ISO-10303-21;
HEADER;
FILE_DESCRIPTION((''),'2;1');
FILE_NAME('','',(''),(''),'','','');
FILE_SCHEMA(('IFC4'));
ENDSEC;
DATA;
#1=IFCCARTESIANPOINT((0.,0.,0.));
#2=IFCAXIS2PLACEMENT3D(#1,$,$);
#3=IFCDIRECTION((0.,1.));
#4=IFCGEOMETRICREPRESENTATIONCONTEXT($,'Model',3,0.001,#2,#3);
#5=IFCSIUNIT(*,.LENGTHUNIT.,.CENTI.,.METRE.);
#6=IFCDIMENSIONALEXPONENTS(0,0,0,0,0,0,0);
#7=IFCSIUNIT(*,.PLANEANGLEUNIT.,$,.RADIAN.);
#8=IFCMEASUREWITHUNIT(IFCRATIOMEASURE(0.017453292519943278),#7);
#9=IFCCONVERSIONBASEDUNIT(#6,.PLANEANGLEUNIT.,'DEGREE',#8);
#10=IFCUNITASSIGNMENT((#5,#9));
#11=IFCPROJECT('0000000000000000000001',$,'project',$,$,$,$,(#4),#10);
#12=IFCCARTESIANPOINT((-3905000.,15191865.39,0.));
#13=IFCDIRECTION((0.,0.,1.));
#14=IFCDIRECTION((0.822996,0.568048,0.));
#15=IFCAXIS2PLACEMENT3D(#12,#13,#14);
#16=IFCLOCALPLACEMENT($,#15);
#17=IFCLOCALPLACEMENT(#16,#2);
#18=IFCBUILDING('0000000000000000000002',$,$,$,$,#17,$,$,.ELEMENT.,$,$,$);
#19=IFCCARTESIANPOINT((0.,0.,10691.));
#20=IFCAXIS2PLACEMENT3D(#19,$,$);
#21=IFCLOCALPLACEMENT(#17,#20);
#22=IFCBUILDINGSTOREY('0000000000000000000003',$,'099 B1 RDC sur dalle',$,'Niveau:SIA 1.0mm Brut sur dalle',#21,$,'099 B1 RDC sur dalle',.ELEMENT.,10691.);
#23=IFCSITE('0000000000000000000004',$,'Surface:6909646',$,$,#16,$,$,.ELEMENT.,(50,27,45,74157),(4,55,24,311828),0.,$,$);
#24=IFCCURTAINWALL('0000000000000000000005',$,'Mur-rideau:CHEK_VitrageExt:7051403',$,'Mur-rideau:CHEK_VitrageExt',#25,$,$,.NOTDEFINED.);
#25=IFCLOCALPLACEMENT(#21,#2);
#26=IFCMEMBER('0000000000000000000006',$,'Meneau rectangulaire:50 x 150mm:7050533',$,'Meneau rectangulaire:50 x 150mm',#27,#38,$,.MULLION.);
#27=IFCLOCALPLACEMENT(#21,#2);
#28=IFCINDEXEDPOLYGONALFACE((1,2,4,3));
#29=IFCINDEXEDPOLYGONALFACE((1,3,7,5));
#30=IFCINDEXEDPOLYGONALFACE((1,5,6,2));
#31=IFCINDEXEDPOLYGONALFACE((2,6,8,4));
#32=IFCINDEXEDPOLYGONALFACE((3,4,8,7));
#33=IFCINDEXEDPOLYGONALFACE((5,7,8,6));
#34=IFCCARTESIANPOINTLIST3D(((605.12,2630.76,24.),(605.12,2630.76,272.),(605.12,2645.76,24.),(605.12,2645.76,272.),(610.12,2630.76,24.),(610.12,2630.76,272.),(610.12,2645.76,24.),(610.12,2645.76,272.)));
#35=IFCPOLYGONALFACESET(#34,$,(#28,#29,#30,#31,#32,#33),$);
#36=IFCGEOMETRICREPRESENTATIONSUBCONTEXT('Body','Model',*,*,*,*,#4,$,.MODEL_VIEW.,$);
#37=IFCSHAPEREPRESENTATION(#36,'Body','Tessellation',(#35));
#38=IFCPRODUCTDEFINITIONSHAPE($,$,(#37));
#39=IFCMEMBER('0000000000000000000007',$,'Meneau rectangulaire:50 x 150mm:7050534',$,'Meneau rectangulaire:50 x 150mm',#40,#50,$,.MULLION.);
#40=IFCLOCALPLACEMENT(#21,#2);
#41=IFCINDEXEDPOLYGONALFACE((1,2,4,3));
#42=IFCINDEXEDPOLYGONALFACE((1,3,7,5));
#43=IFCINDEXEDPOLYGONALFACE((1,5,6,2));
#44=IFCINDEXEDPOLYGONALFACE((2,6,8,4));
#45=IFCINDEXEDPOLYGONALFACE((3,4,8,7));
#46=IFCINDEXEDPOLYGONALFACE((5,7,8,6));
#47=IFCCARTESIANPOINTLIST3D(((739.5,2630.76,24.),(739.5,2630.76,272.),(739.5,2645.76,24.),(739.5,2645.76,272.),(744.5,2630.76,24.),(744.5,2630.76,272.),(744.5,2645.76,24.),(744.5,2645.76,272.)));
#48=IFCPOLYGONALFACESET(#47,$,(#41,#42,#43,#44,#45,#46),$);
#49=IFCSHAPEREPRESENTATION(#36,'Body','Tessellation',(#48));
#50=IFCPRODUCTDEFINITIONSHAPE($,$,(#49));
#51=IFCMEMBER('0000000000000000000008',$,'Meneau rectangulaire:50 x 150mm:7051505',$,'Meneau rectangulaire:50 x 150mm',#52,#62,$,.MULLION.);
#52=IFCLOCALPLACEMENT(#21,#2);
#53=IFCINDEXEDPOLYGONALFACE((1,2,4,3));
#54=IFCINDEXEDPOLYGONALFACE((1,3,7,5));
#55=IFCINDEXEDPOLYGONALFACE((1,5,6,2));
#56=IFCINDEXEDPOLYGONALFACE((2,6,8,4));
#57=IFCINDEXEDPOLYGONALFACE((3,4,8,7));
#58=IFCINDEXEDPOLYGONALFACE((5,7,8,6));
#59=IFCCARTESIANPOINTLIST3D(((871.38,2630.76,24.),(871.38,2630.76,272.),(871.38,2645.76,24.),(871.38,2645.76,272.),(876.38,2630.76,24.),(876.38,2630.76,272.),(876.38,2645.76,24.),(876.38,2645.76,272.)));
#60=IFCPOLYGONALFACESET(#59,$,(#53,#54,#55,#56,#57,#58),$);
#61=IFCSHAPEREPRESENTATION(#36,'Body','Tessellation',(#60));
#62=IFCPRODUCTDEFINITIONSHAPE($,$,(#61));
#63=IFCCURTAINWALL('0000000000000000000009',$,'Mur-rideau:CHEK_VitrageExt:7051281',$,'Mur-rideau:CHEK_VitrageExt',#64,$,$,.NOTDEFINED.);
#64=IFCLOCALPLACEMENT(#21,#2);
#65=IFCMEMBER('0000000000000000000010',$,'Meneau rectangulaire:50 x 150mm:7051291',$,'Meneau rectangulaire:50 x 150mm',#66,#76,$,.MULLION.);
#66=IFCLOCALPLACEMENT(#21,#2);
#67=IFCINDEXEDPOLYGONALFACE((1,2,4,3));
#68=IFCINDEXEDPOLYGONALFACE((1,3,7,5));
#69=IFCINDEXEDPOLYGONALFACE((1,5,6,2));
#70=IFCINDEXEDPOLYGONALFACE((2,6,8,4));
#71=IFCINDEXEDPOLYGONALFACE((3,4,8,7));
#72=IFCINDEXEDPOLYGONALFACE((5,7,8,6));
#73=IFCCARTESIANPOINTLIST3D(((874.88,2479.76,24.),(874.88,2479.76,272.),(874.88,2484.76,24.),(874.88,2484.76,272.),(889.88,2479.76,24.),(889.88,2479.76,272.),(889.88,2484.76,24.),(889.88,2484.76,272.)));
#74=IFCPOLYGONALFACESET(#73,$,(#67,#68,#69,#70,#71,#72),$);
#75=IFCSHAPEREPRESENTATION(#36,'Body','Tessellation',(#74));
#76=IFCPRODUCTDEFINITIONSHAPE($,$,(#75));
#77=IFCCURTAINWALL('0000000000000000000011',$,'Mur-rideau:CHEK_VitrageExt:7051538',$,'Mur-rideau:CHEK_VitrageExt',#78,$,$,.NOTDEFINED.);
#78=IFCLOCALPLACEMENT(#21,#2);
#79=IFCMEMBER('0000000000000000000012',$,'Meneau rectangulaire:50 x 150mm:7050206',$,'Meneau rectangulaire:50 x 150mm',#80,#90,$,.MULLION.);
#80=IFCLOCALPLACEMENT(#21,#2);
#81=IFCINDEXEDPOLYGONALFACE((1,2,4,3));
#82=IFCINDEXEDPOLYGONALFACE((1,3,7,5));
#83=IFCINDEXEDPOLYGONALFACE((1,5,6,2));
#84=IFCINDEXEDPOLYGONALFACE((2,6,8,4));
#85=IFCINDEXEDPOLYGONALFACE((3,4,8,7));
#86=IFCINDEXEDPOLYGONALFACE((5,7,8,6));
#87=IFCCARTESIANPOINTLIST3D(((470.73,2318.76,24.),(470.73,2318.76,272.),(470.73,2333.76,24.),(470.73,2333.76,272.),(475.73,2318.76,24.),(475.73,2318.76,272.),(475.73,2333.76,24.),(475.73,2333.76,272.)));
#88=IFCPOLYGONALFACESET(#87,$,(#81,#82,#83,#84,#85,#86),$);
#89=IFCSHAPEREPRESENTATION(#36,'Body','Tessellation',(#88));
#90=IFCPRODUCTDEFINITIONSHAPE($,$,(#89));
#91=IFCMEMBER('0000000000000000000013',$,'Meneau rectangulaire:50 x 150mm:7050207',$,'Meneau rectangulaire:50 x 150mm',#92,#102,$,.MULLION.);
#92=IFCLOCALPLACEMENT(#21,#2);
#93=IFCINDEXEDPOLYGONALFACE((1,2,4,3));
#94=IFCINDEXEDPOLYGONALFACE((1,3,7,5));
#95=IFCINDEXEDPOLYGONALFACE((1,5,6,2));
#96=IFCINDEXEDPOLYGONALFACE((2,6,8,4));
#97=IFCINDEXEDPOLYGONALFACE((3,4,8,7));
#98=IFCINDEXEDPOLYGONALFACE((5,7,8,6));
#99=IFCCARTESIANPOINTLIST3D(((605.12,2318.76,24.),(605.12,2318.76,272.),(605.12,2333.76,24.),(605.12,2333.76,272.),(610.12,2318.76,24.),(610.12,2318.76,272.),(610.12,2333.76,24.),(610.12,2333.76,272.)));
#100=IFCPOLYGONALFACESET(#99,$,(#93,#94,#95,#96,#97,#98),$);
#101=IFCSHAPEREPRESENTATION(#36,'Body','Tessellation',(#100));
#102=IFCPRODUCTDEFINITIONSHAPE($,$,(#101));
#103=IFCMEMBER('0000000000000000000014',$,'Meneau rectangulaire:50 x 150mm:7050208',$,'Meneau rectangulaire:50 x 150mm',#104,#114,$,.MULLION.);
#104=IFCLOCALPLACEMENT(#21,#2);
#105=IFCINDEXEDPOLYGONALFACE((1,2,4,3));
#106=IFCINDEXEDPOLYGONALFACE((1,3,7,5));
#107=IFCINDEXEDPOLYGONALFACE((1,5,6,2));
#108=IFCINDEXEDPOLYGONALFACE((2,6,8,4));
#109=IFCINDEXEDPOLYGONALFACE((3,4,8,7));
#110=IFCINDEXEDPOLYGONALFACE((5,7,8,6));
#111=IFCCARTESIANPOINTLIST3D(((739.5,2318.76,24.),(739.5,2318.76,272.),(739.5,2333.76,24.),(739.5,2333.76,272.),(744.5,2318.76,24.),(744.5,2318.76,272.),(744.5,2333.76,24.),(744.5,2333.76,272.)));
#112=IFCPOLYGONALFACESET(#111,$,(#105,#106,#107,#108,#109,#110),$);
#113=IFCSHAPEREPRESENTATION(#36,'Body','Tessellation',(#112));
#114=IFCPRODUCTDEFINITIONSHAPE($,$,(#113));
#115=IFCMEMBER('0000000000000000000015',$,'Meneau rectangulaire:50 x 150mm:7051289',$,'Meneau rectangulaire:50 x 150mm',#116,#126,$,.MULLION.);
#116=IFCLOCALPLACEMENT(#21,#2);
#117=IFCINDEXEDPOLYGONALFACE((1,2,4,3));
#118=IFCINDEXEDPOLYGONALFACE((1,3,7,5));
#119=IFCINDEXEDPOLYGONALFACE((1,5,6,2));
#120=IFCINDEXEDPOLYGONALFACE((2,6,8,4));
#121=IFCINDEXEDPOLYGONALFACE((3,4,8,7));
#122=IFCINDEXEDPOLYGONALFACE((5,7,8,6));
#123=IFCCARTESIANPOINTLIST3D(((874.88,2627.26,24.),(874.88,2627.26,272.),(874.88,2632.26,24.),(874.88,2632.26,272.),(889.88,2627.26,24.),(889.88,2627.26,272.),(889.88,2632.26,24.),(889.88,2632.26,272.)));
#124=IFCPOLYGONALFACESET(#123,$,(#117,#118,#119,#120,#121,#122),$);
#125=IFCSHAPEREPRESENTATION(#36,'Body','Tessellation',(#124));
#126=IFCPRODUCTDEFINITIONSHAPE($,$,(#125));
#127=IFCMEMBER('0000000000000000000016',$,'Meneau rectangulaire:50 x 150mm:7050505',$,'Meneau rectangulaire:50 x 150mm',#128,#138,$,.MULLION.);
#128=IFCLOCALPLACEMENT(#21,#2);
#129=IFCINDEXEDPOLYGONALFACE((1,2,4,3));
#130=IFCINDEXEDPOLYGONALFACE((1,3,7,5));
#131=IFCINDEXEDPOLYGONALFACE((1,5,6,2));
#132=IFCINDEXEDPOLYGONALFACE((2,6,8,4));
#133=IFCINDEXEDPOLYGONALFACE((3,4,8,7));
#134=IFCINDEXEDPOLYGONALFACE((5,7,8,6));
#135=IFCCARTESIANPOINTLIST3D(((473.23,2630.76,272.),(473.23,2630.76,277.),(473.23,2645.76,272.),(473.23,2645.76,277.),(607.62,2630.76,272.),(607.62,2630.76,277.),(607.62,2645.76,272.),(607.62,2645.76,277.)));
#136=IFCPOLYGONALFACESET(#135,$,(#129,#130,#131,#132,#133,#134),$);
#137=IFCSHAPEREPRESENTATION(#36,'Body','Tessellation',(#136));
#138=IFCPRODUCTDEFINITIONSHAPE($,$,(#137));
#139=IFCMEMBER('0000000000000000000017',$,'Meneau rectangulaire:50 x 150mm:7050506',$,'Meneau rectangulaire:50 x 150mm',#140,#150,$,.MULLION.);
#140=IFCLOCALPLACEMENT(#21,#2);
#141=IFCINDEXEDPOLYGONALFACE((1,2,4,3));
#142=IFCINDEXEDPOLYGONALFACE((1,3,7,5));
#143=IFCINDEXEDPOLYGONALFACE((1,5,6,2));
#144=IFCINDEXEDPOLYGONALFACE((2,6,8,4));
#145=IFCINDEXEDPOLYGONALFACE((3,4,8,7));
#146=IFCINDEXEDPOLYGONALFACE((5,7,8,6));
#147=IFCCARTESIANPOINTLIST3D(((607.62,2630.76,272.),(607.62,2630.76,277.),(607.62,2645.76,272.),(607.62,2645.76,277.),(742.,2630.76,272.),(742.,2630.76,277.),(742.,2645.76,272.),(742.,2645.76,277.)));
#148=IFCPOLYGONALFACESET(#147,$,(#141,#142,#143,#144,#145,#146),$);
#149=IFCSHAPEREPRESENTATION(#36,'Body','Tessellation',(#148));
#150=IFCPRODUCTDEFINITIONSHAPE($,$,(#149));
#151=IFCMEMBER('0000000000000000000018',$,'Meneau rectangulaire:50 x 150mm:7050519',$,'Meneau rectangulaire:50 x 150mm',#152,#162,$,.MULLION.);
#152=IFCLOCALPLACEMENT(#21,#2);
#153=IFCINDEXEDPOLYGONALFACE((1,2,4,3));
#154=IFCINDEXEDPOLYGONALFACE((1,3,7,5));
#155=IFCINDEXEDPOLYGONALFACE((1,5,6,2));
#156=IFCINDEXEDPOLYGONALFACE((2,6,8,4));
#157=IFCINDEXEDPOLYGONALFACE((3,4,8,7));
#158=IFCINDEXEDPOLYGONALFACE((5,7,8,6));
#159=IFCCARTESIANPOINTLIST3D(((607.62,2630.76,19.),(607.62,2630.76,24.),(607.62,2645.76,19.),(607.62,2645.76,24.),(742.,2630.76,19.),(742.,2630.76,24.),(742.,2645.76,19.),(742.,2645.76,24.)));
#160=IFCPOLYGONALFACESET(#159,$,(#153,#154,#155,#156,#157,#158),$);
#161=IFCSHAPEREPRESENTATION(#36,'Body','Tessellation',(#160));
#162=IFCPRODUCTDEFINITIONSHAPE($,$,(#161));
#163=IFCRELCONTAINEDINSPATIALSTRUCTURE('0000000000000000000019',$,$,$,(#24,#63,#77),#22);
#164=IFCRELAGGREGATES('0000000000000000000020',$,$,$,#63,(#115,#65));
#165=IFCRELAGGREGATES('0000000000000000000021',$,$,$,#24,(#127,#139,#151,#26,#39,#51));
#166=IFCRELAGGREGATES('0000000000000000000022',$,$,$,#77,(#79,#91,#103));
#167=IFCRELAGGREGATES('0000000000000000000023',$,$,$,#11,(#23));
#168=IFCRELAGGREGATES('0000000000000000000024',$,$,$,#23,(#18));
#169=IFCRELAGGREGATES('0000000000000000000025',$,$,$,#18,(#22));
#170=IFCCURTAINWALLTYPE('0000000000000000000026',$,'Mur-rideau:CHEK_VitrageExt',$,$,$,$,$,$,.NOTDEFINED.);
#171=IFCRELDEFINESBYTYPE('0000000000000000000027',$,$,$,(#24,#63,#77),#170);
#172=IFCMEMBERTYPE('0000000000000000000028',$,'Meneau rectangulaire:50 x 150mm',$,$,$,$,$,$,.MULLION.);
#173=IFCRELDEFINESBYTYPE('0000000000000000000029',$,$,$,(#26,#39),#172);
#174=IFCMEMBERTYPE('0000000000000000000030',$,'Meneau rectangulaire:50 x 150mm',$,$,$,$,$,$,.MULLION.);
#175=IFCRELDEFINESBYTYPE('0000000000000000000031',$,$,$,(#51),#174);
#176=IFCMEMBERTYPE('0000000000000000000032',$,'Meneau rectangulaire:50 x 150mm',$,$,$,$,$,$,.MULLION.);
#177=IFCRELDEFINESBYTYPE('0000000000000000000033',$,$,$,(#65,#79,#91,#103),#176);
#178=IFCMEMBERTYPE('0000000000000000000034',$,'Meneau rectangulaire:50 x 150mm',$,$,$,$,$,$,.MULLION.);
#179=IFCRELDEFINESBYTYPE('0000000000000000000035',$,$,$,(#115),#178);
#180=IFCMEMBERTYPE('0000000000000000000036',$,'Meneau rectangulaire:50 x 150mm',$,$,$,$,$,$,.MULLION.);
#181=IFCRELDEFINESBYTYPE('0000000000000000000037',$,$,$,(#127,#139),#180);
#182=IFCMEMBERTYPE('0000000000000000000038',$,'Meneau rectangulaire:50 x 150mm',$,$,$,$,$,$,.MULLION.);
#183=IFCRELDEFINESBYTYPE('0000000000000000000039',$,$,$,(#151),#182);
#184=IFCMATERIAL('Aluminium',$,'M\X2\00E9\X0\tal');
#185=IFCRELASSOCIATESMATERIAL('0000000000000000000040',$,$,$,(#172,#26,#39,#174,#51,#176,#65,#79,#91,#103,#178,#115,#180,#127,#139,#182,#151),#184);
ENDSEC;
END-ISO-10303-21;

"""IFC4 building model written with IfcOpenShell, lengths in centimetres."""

from ifc_helpers import new_model, entity, si_unit, converted_unit, direction, frame, origin, place, context, subcontext, project, spatial, indexed_curve, outline, extrude, source, transform, mapped, material, type_object, type_shapes, element, aggregate, save


model = new_model("IFC4")

# Units and contexts
model_context = context("Model", 3, precision=0.001, world=origin(), true_north=direction((0.0, 1.0)))
body_context = subcontext(model_context, "Body", "Model", "MODEL_VIEW")
ifc_project = project(units=[si_unit("LENGTHUNIT", "METRE", prefix="CENTI"), converted_unit("PLANEANGLEUNIT", "DEGREE", entity("IfcRatioMeasure", 0.017453292519943278), si_unit("PLANEANGLEUNIT", "RADIAN"), dimensions=[0, 0, 0, 0, 0, 0, 0])], contexts=[model_context])

# Site, building, storey
site_placement = place(None, frame((-3905000.0, 15191865.39, 0.0), z_axis=(0.0, 0.0, 1.0), x_axis=(0.822996, 0.568048, 0.0)))
site = spatial("IfcSite", under=ifc_project, at=site_placement, Name="Surface:6909646", CompositionType="ELEMENT", RefLatitude=(50, 27, 45, 74157), RefLongitude=(4, 55, 24, 311828), RefElevation=0.0)
building_placement = place(site_placement, origin())
building = spatial("IfcBuilding", under=site, at=building_placement, CompositionType="ELEMENT")
storey_placement = place(building_placement, frame((0.0, 0.0, 10691.0)))
storey = spatial("IfcBuildingStorey", under=building, at=storey_placement, Name="099 B1 RDC sur dalle", ObjectType="Niveau:SIA 1.0mm Brut sur dalle", LongName="099 B1 RDC sur dalle", CompositionType="ELEMENT", Elevation=10691.0)

# Curtain wall, members
curtain_wall_type = type_object("IfcCurtainWallType", Name="Mur-rideau:CHEK_VitrageExt", PredefinedType="NOTDEFINED")
curtain_wall_1_placement = place(storey_placement, frame((0.0, 0.0, -10691.0)))
curtain_wall_1 = element("IfcCurtainWall", 1, at=curtain_wall_1_placement, inside=storey, type_object=curtain_wall_type, Name="Mur-rideau:CHEK_VitrageExt:7051403", ObjectType="Mur-rideau:CHEK_VitrageExt", PredefinedType="NOTDEFINED")
ifc_material_1 = material(Name="Aluminium", Category="Métal")
member_type_1 = type_object("IfcMemberType", Name="Meneau rectangulaire:50 x 150mm", PredefinedType="MULLION", material=ifc_material_1)
shared_shape_1 = source(origin(), body_context, "Body", "SweptSolid", [
    extrude(outline(indexed_curve([(-7.5, -2.5), (7.5, -2.5), (7.5, 2.5), (-7.5, 2.5), (-7.5, -2.5)], self_intersect=False)), frame((0.0, -6.0, -248.0), z_axis=(0.0, 0.0, 1.0), x_axis=(0.0, -1.0, 0.0)), (0.0, 0.0, 1.0), 248.0),
])
type_shapes(member_type_1, [shared_shape_1])
member_1_placement = place(curtain_wall_1_placement, frame((607.62, 2632.26, 10715.0), z_axis=(0.0, 0.0, -1.0), x_axis=(1.0, 0.0, 0.0)))
member_1 = element("IfcMember", 2, at=member_1_placement, type_object=member_type_1, material=ifc_material_1, Name="Meneau rectangulaire:50 x 150mm:7050533", ObjectType="Meneau rectangulaire:50 x 150mm", PredefinedType="MULLION", context=body_context, shape_type="MappedRepresentation", body=[
    mapped(shared_shape_1, transform((0.0, 0.0, 0.0), scale=1.0)),
])
member_2_placement = place(curtain_wall_1_placement, frame((742.0, 2632.26, 10715.0), z_axis=(0.0, 0.0, -1.0), x_axis=(1.0, 0.0, 0.0)))
member_2 = element("IfcMember", 3, at=member_2_placement, type_object=member_type_1, material=ifc_material_1, Name="Meneau rectangulaire:50 x 150mm:7050534", ObjectType="Meneau rectangulaire:50 x 150mm", PredefinedType="MULLION", context=body_context, shape_type="MappedRepresentation", body=[
    mapped(shared_shape_1, transform((0.0, 0.0, 0.0), scale=1.0)),
])
member_type_2 = type_object("IfcMemberType", Name="Meneau rectangulaire:50 x 150mm", PredefinedType="MULLION", material=ifc_material_1)
shared_shape_2 = source(origin(), body_context, "Body", "SweptSolid", [
    extrude(outline(indexed_curve([(-7.5, -2.5), (7.5, -2.5), (7.5, 2.5), (-7.5, 2.5), (-7.5, -2.5)], self_intersect=False)), frame((-2.5, -6.0, -248.0), z_axis=(0.0, 0.0, 1.0), x_axis=(0.0, -1.0, 0.0)), (0.0, 0.0, 1.0), 248.0),
])
type_shapes(member_type_2, [shared_shape_2])
member_3_placement = place(curtain_wall_1_placement, frame((876.38, 2632.26, 10715.0), z_axis=(0.0, 0.0, -1.0), x_axis=(1.0, 0.0, 0.0)))
member_3 = element("IfcMember", 4, at=member_3_placement, type_object=member_type_2, material=ifc_material_1, Name="Meneau rectangulaire:50 x 150mm:7051505", ObjectType="Meneau rectangulaire:50 x 150mm", PredefinedType="MULLION", context=body_context, shape_type="MappedRepresentation", body=[
    mapped(shared_shape_2, transform((0.0, 0.0, 0.0), scale=1.0)),
])

# Curtain wall, member
curtain_wall_2_placement = place(storey_placement, frame((0.0, 0.0, -10691.0)))
curtain_wall_2 = element("IfcCurtainWall", 5, at=curtain_wall_2_placement, inside=storey, type_object=curtain_wall_type, Name="Mur-rideau:CHEK_VitrageExt:7051281", ObjectType="Mur-rideau:CHEK_VitrageExt", PredefinedType="NOTDEFINED")
member_type_3 = type_object("IfcMemberType", Name="Meneau rectangulaire:50 x 150mm", PredefinedType="MULLION", material=ifc_material_1)
shared_shape_3 = source(origin(), body_context, "Body", "SweptSolid", [
    extrude(outline(indexed_curve([(-7.5, -2.5), (7.5, -2.5), (7.5, 2.5), (-7.5, 2.5), (-7.5, -2.5)], self_intersect=False)), frame((0.0, 6.0, -248.0), z_axis=(0.0, 0.0, 1.0), x_axis=(0.0, -1.0, 0.0)), (0.0, 0.0, 1.0), 248.0),
])
type_shapes(member_type_3, [shared_shape_3])
member_4_placement = place(curtain_wall_2_placement, frame((876.38, 2482.26, 10715.0), z_axis=(0.0, 0.0, -1.0), x_axis=(0.0, 1.0, 0.0)))
member_4 = element("IfcMember", 6, at=member_4_placement, type_object=member_type_3, material=ifc_material_1, Name="Meneau rectangulaire:50 x 150mm:7051291", ObjectType="Meneau rectangulaire:50 x 150mm", PredefinedType="MULLION", context=body_context, shape_type="MappedRepresentation", body=[
    mapped(shared_shape_3, transform((0.0, 0.0, 0.0), scale=1.0)),
])

# Curtain wall, members
curtain_wall_3_placement = place(storey_placement, frame((0.0, 0.0, -10691.0)))
curtain_wall_3 = element("IfcCurtainWall", 7, at=curtain_wall_3_placement, inside=storey, type_object=curtain_wall_type, Name="Mur-rideau:CHEK_VitrageExt:7051538", ObjectType="Mur-rideau:CHEK_VitrageExt", PredefinedType="NOTDEFINED")
member_5_placement = place(curtain_wall_3_placement, frame((473.23, 2332.26, 10715.0), z_axis=(0.0, 0.0, -1.0), x_axis=(1.0, 0.0, 0.0)))
member_5 = element("IfcMember", 8, at=member_5_placement, type_object=member_type_3, material=ifc_material_1, Name="Meneau rectangulaire:50 x 150mm:7050206", ObjectType="Meneau rectangulaire:50 x 150mm", PredefinedType="MULLION", context=body_context, shape_type="MappedRepresentation", body=[
    mapped(shared_shape_3, transform((0.0, 0.0, 0.0), scale=1.0)),
])
member_6_placement = place(curtain_wall_3_placement, frame((607.62, 2332.26, 10715.0), z_axis=(0.0, 0.0, -1.0), x_axis=(1.0, 0.0, 0.0)))
member_6 = element("IfcMember", 9, at=member_6_placement, type_object=member_type_3, material=ifc_material_1, Name="Meneau rectangulaire:50 x 150mm:7050207", ObjectType="Meneau rectangulaire:50 x 150mm", PredefinedType="MULLION", context=body_context, shape_type="MappedRepresentation", body=[
    mapped(shared_shape_3, transform((0.0, 0.0, 0.0), scale=1.0)),
])
member_7_placement = place(curtain_wall_3_placement, frame((742.0, 2332.26, 10715.0), z_axis=(0.0, 0.0, -1.0), x_axis=(1.0, 0.0, 0.0)))
member_7 = element("IfcMember", 10, at=member_7_placement, type_object=member_type_3, material=ifc_material_1, Name="Meneau rectangulaire:50 x 150mm:7050208", ObjectType="Meneau rectangulaire:50 x 150mm", PredefinedType="MULLION", context=body_context, shape_type="MappedRepresentation", body=[
    mapped(shared_shape_3, transform((0.0, 0.0, 0.0), scale=1.0)),
])

# Members
member_type_4 = type_object("IfcMemberType", Name="Meneau rectangulaire:50 x 150mm", PredefinedType="MULLION", material=ifc_material_1)
shared_shape_4 = source(origin(), body_context, "Body", "SweptSolid", [
    extrude(outline(indexed_curve([(-7.5, -2.5), (7.5, -2.5), (7.5, 2.5), (-7.5, 2.5), (-7.5, -2.5)], self_intersect=False)), frame((-2.5, 6.0, -248.0), z_axis=(0.0, 0.0, 1.0), x_axis=(0.0, -1.0, 0.0)), (0.0, 0.0, 1.0), 248.0),
])
type_shapes(member_type_4, [shared_shape_4])
member_8_placement = place(curtain_wall_2_placement, frame((876.38, 2632.26, 10715.0), z_axis=(0.0, 0.0, -1.0), x_axis=(0.0, 1.0, 0.0)))
member_8 = element("IfcMember", 11, at=member_8_placement, type_object=member_type_4, material=ifc_material_1, Name="Meneau rectangulaire:50 x 150mm:7051289", ObjectType="Meneau rectangulaire:50 x 150mm", PredefinedType="MULLION", context=body_context, shape_type="MappedRepresentation", body=[
    mapped(shared_shape_4, transform((0.0, 0.0, 0.0), scale=1.0)),
])
member_type_5 = type_object("IfcMemberType", Name="Meneau rectangulaire:50 x 150mm", PredefinedType="MULLION", material=ifc_material_1)
shared_shape_5 = source(origin(), body_context, "Body", "SweptSolid", [
    extrude(outline(indexed_curve([(-7.5, -2.5), (7.5, -2.5), (7.5, 2.5), (-7.5, 2.5), (-7.5, -2.5)], self_intersect=False)), frame((-2.5, -6.0, -134.38), z_axis=(0.0, 0.0, 1.0), x_axis=(0.0, -1.0, 0.0)), (0.0, 0.0, 1.0), 134.38),
])
type_shapes(member_type_5, [shared_shape_5])
member_9_placement = place(curtain_wall_1_placement, frame((607.62, 2632.26, 10968.0), z_axis=(1.0, 0.0, 0.0), x_axis=(0.0, 0.0, 1.0)))
member_9 = element("IfcMember", 12, at=member_9_placement, type_object=member_type_5, material=ifc_material_1, Name="Meneau rectangulaire:50 x 150mm:7050505", ObjectType="Meneau rectangulaire:50 x 150mm", PredefinedType="MULLION", context=body_context, shape_type="MappedRepresentation", body=[
    mapped(shared_shape_5, transform((0.0, 0.0, 0.0), scale=1.0)),
])
member_10_placement = place(curtain_wall_1_placement, frame((742.0, 2632.26, 10968.0), z_axis=(1.0, 0.0, 0.0), x_axis=(0.0, 0.0, 1.0)))
member_10 = element("IfcMember", 13, at=member_10_placement, type_object=member_type_5, material=ifc_material_1, Name="Meneau rectangulaire:50 x 150mm:7050506", ObjectType="Meneau rectangulaire:50 x 150mm", PredefinedType="MULLION", context=body_context, shape_type="MappedRepresentation", body=[
    mapped(shared_shape_5, transform((0.0, 0.0, 0.0), scale=1.0)),
])
member_type_6 = type_object("IfcMemberType", Name="Meneau rectangulaire:50 x 150mm", PredefinedType="MULLION", material=ifc_material_1)
shared_shape_6 = source(origin(), body_context, "Body", "SweptSolid", [
    extrude(outline(indexed_curve([(-7.5, -2.5), (7.5, -2.5), (7.5, 2.5), (-7.5, 2.5), (-7.5, -2.5)], self_intersect=False)), frame((-2.5, -6.0, -134.38), z_axis=(0.0, 0.0, 1.0), x_axis=(0.0, -1.0, 0.0)), (0.0, 0.0, 1.0), 134.38),
])
type_shapes(member_type_6, [shared_shape_6])
member_11_placement = place(curtain_wall_1_placement, frame((607.62, 2632.26, 10710.0), z_axis=(-1.0, 0.0, 0.0), x_axis=(0.0, 0.0, -1.0)))
member_11 = element("IfcMember", 14, at=member_11_placement, type_object=member_type_6, material=ifc_material_1, Name="Meneau rectangulaire:50 x 150mm:7050519", ObjectType="Meneau rectangulaire:50 x 150mm", PredefinedType="MULLION", context=body_context, shape_type="MappedRepresentation", body=[
    mapped(shared_shape_6, transform((0.0, 0.0, 0.0), scale=1.0)),
])

aggregate(curtain_wall_2, [member_8, member_4])
aggregate(curtain_wall_1, [member_9, member_10, member_11, member_1, member_2, member_3])
aggregate(curtain_wall_3, [member_5, member_6, member_7])

save(model, "model.ifc")
